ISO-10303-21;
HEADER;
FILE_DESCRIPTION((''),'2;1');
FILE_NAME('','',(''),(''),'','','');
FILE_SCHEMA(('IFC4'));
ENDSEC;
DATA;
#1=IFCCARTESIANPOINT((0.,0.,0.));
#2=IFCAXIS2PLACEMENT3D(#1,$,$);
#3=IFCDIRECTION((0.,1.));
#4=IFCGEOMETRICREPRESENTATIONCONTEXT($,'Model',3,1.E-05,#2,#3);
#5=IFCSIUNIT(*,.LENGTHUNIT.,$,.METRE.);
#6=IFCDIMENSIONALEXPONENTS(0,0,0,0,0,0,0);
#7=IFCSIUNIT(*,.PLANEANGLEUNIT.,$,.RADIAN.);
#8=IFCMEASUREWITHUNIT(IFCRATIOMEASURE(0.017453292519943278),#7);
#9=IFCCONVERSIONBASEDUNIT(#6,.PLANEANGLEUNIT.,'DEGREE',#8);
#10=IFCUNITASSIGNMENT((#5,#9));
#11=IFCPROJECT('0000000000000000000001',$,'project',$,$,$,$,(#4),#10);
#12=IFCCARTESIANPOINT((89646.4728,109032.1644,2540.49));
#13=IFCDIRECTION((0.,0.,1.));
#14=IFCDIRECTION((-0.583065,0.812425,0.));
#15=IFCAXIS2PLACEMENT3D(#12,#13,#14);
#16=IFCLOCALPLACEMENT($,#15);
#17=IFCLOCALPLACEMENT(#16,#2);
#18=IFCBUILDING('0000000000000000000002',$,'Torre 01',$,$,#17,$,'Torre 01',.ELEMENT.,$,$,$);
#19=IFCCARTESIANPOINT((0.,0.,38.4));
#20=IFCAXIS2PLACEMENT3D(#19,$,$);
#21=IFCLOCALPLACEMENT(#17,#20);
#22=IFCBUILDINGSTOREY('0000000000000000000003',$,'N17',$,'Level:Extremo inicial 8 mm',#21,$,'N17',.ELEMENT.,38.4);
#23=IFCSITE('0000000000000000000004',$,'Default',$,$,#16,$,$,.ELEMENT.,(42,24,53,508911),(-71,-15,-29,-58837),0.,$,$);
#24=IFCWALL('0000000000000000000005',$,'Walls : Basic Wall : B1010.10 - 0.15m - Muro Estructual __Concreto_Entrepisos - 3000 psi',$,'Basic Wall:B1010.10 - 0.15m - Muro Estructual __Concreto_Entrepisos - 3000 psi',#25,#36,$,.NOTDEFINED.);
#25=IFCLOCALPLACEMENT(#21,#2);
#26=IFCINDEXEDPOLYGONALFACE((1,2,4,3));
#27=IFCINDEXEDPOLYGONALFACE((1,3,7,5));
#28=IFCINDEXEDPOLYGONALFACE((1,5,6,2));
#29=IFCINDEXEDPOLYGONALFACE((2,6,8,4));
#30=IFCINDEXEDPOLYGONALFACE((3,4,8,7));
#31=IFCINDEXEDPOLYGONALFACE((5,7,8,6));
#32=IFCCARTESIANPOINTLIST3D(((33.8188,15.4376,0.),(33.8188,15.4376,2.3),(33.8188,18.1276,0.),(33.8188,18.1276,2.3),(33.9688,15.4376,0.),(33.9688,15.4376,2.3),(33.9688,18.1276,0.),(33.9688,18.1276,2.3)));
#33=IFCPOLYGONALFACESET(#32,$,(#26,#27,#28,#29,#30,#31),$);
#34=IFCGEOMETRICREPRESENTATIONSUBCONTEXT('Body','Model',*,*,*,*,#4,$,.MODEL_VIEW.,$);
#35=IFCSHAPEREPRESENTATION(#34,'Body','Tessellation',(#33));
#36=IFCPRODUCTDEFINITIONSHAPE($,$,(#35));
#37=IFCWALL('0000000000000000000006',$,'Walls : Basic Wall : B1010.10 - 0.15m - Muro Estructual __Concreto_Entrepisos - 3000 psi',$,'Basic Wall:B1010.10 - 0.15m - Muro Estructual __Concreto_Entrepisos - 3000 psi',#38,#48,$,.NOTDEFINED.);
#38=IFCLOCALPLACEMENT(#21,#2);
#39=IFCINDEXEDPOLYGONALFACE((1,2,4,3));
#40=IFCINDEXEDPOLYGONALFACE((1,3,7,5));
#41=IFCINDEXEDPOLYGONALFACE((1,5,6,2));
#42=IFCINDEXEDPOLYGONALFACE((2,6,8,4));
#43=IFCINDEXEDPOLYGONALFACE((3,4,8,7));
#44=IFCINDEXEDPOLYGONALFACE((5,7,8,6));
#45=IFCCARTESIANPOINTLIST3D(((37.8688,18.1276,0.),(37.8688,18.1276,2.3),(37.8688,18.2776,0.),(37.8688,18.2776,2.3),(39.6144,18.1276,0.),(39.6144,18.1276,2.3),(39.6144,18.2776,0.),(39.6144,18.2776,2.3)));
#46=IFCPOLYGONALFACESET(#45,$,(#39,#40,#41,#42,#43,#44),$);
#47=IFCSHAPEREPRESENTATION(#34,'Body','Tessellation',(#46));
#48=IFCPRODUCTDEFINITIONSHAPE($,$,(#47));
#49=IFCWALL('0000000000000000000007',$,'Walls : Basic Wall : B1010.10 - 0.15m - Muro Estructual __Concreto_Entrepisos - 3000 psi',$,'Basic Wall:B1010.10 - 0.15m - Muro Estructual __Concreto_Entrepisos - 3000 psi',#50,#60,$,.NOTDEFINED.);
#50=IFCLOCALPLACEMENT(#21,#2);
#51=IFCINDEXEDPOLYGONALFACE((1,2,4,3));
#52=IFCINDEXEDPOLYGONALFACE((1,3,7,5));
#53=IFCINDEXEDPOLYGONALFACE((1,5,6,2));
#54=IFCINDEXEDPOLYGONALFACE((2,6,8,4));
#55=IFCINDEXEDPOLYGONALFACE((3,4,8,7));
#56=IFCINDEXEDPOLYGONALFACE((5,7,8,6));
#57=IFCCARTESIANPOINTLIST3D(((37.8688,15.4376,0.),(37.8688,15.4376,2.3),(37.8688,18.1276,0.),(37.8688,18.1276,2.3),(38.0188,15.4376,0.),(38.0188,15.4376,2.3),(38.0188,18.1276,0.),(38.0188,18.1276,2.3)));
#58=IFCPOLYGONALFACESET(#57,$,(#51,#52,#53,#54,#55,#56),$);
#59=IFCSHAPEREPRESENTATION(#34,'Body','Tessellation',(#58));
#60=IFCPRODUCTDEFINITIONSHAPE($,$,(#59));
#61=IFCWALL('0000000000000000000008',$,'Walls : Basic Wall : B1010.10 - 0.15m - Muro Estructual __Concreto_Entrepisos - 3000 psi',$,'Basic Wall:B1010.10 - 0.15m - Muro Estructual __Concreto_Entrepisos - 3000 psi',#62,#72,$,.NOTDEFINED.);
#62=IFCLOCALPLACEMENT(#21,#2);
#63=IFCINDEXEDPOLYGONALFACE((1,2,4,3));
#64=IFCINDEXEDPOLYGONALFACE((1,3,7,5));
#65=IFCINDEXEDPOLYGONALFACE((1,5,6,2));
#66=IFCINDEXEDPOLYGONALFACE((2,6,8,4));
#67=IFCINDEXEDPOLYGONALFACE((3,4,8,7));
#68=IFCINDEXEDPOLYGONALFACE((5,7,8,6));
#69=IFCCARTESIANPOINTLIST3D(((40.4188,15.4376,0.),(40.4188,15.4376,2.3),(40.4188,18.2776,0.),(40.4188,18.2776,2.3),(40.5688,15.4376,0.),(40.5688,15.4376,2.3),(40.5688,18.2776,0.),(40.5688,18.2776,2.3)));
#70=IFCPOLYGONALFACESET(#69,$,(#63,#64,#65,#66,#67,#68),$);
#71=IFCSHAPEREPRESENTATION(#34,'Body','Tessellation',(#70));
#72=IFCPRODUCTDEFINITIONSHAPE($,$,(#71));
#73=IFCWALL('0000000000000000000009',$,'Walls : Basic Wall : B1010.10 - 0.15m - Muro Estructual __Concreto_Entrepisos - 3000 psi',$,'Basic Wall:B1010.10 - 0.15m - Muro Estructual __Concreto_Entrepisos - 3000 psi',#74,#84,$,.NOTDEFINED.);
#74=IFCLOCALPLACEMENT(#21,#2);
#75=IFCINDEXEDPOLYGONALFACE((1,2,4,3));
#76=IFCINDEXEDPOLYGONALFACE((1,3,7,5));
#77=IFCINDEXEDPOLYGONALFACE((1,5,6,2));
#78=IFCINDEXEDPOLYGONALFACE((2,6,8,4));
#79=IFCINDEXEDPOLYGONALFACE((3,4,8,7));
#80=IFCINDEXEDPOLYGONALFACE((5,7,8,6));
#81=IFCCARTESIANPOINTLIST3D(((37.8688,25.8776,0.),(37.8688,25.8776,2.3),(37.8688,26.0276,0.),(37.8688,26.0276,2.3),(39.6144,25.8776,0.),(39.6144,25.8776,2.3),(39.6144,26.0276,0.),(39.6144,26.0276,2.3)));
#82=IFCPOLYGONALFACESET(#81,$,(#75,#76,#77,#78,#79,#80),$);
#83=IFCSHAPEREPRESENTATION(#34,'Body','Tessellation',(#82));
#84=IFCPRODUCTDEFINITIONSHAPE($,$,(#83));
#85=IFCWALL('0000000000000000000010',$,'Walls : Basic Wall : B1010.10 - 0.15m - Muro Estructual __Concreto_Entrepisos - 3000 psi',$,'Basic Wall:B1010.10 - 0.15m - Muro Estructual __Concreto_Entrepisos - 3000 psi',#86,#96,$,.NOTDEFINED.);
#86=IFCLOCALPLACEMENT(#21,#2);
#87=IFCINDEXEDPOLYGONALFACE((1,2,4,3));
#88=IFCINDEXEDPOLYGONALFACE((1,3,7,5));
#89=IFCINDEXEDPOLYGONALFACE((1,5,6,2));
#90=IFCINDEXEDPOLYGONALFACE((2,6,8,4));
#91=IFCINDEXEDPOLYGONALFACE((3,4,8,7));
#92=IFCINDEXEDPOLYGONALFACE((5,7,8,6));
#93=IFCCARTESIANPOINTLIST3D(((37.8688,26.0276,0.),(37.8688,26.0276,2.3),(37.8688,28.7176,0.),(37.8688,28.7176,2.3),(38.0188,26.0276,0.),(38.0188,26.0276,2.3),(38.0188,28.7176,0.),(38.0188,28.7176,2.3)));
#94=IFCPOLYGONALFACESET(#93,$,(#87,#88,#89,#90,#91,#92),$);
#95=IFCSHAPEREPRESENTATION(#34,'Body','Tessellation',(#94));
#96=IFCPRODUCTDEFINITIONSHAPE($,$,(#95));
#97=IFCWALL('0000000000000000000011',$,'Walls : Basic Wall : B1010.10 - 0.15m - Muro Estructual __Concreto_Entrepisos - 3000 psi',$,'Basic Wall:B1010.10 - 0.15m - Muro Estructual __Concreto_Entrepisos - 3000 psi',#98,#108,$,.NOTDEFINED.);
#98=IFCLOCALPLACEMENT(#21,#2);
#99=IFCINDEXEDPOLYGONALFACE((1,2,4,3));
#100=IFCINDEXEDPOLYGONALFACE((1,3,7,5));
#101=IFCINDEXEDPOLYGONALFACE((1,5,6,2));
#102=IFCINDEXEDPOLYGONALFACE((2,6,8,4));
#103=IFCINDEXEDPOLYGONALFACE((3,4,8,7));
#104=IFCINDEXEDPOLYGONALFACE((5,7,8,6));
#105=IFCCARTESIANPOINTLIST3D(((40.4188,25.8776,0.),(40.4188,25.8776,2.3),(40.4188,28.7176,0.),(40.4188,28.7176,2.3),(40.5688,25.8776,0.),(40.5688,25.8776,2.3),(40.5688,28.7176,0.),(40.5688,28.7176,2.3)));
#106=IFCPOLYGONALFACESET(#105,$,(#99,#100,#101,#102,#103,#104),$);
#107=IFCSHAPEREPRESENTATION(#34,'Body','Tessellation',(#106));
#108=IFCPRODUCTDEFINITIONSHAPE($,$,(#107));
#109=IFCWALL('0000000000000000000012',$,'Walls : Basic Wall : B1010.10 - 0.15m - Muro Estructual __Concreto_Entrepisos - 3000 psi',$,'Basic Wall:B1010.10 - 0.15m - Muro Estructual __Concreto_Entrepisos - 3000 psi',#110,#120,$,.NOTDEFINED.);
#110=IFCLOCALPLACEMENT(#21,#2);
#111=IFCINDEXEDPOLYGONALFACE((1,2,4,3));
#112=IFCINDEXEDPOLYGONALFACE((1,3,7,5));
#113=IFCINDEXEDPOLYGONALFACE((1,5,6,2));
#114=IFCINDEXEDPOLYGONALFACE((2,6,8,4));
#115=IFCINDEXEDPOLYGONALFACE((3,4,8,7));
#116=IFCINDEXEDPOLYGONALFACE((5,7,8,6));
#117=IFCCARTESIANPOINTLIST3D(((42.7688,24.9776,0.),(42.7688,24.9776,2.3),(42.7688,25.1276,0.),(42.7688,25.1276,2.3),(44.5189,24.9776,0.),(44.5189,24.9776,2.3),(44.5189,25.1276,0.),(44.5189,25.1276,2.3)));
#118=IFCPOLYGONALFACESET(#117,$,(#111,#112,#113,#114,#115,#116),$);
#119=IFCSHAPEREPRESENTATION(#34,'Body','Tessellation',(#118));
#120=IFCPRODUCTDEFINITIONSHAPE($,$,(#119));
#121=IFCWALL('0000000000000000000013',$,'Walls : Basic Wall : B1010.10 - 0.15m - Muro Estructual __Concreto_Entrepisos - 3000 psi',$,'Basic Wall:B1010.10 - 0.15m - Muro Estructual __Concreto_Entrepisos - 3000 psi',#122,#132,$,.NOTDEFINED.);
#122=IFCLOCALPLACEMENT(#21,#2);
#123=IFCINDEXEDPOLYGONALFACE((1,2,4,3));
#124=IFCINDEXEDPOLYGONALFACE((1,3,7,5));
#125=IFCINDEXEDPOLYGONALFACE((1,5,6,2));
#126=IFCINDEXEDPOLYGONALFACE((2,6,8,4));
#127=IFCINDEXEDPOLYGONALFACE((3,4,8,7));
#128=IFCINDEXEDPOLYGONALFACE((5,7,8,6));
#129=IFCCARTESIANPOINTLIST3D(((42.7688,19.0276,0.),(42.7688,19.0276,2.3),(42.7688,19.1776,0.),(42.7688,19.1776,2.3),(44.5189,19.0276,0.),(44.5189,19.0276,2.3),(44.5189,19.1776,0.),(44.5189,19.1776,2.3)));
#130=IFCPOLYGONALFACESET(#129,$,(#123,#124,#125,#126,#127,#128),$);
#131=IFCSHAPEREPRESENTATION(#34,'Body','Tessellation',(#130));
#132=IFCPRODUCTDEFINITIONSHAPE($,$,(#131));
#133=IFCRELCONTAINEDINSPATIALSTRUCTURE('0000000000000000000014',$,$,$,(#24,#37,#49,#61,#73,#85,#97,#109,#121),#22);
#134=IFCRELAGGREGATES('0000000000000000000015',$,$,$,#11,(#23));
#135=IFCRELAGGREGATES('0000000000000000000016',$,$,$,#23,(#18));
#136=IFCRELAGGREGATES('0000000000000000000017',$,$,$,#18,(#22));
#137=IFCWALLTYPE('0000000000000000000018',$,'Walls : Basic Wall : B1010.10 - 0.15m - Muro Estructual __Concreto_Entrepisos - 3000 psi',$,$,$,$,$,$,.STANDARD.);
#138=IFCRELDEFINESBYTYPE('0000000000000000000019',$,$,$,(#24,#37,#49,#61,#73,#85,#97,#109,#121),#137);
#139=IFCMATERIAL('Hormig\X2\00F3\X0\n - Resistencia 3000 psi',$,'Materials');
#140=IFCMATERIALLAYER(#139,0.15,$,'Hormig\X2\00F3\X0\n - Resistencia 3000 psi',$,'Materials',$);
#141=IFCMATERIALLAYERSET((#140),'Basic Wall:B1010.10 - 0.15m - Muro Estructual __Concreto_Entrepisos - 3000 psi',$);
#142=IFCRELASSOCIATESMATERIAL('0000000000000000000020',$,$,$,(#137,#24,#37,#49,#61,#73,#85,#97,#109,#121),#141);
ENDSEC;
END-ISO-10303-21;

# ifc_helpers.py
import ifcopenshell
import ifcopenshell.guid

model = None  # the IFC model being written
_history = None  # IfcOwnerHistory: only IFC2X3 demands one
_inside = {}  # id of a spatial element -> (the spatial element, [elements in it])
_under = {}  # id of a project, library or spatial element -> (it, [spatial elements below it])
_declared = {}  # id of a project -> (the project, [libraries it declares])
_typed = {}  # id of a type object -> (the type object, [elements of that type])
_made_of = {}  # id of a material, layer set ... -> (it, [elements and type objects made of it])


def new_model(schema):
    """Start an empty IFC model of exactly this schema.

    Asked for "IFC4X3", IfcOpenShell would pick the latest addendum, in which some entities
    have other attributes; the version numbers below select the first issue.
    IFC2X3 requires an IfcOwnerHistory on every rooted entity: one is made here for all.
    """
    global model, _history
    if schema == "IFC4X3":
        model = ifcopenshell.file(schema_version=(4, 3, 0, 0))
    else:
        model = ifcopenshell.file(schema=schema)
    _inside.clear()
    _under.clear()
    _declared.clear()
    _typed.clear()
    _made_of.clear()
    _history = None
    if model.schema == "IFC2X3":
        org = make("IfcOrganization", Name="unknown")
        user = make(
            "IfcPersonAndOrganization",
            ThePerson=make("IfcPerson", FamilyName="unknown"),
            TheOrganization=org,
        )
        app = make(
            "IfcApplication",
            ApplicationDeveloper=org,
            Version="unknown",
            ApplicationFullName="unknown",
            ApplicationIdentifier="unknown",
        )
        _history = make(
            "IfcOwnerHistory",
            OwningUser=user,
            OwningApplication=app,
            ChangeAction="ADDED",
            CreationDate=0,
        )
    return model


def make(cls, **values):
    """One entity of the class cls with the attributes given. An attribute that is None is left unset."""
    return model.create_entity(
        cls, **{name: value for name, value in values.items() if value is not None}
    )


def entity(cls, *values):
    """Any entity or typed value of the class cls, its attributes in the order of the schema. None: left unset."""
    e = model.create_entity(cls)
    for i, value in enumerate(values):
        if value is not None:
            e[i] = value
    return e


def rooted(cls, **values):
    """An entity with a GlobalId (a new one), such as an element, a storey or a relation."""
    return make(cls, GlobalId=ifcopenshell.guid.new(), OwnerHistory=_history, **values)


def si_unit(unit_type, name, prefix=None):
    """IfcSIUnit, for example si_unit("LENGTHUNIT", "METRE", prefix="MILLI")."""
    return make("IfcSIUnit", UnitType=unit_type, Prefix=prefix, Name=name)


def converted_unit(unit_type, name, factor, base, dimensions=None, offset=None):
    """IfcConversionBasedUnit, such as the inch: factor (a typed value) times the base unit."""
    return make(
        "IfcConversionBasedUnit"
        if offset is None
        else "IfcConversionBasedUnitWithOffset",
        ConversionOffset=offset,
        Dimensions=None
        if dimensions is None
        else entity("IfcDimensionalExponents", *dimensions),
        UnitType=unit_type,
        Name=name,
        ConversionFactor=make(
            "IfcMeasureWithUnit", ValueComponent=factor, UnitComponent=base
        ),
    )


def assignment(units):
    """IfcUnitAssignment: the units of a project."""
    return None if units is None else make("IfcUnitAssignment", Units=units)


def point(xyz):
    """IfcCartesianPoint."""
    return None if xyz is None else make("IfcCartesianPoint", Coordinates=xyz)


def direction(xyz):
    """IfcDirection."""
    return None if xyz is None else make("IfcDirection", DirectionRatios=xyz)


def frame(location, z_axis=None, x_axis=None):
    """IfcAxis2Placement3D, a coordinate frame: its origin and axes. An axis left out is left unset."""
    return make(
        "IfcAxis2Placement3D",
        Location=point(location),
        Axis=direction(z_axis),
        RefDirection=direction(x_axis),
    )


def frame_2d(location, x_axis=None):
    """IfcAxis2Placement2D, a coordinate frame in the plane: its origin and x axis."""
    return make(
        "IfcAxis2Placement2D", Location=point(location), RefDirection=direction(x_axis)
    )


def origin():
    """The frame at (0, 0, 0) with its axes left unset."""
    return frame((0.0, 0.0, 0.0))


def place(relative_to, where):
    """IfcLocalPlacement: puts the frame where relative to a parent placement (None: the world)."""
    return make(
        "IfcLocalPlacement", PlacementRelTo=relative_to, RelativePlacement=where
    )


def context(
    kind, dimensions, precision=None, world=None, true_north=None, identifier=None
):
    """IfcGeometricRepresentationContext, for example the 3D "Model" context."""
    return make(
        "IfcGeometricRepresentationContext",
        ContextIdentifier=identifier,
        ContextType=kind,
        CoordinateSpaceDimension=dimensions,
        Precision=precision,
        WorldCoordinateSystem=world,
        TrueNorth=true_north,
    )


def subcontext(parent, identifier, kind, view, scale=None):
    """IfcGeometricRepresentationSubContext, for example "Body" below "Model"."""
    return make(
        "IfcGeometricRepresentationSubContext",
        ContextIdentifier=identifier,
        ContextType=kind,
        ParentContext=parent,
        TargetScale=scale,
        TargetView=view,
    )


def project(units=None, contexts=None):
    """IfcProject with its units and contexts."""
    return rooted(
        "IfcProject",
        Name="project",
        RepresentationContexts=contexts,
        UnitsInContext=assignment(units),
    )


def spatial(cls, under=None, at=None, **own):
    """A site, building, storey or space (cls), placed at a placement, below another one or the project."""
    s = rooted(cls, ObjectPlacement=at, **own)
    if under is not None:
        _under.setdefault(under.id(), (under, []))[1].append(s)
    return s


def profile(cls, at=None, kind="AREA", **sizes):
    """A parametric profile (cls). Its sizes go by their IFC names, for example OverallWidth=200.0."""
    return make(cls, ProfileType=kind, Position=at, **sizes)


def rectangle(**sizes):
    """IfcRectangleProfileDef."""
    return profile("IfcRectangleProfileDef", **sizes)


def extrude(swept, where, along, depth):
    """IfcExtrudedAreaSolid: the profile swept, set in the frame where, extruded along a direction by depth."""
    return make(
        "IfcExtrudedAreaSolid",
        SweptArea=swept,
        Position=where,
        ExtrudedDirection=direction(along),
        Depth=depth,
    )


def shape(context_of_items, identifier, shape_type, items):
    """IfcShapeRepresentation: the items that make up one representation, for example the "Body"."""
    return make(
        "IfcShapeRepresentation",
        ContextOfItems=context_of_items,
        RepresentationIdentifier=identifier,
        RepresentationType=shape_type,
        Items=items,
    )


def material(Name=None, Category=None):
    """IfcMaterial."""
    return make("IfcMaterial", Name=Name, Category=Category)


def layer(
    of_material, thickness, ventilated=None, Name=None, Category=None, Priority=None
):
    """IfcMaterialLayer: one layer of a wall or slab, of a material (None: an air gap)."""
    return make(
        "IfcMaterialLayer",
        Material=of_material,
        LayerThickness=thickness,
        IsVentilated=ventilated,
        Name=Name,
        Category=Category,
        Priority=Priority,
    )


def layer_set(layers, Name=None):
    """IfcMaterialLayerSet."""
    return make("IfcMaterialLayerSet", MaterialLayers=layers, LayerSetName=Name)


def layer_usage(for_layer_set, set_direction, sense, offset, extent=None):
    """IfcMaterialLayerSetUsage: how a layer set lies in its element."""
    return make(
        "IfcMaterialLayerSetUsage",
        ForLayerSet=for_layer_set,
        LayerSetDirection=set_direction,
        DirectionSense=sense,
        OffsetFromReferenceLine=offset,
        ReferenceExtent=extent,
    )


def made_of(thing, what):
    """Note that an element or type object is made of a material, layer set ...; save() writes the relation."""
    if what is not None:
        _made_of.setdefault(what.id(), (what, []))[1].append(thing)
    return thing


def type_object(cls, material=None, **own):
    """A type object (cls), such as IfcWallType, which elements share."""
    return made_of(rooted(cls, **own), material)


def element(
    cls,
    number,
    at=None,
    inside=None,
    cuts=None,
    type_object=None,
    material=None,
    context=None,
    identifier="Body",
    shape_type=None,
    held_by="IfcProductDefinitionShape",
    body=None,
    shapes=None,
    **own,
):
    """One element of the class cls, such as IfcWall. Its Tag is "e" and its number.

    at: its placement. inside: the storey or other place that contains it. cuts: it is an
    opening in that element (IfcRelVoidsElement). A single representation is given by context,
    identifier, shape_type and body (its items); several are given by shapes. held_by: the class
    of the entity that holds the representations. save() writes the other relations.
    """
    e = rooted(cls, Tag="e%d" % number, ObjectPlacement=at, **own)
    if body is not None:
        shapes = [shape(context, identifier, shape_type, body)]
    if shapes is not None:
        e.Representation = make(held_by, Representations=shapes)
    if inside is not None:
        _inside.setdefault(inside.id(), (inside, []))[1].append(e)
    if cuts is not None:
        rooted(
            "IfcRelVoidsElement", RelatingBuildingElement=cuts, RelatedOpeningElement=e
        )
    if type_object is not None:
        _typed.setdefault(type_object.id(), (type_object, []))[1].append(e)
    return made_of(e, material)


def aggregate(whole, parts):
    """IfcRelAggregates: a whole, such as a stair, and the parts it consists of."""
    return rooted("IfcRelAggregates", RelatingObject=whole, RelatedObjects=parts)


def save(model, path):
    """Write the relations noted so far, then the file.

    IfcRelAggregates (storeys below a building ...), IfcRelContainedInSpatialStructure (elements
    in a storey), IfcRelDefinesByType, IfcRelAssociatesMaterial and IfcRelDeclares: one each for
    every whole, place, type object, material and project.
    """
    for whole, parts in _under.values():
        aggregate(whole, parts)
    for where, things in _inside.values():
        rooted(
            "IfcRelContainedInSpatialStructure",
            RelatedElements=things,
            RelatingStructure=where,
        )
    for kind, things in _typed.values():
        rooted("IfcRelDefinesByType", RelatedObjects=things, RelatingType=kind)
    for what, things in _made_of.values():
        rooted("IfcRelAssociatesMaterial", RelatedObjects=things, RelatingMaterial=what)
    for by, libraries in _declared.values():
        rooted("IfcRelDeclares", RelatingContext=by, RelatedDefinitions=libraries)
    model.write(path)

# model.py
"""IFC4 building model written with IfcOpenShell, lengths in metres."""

from ifc_helpers import new_model, entity, si_unit, converted_unit, direction, frame, frame_2d, origin, place, context, subcontext, project, spatial, rectangle, extrude, material, layer, layer_set, layer_usage, type_object, element, save


model = new_model("IFC4")

# Units and contexts
model_context = context("Model", 3, precision=1e-05, world=origin(), true_north=direction((0.0, 1.0)))
body_context = subcontext(model_context, "Body", "Model", "MODEL_VIEW")
ifc_project = project(units=[si_unit("LENGTHUNIT", "METRE"), converted_unit("PLANEANGLEUNIT", "DEGREE", entity("IfcRatioMeasure", 0.017453292519943278), si_unit("PLANEANGLEUNIT", "RADIAN"), dimensions=[0, 0, 0, 0, 0, 0, 0])], contexts=[model_context])

# Site, building, storey
site_placement = place(None, frame((89646.4728, 109032.1644, 2540.49), z_axis=(0.0, 0.0, 1.0), x_axis=(-0.583065, 0.812425, 0.0)))
site = spatial("IfcSite", under=ifc_project, at=site_placement, Name="Default", CompositionType="ELEMENT", RefLatitude=(42, 24, 53, 508911), RefLongitude=(-71, -15, -29, -58837), RefElevation=0.0)
building_placement = place(site_placement, origin())
building = spatial("IfcBuilding", under=site, at=building_placement, Name="Torre 01", LongName="Torre 01", CompositionType="ELEMENT")
storey_placement = place(building_placement, frame((0.0, 0.0, 38.4)))
storey = spatial("IfcBuildingStorey", under=building, at=storey_placement, Name="N17", ObjectType="Level:Extremo inicial 8 mm", LongName="N17", CompositionType="ELEMENT", Elevation=38.4)

# Walls
ifc_material = material(Name="Hormigón - Resistencia 3000 psi", Category="Materials")
ifc_layer_1 = layer(ifc_material, 0.15, Name="Hormigón - Resistencia 3000 psi", Category="Materials")
ifc_layer_set_1 = layer_set([ifc_layer_1], Name="Basic Wall:B1010.10 - 0.15m - Muro Estructual __Concreto_Entrepisos - 3000 psi")
wall_type_1 = type_object("IfcWallType", Name="Walls : Basic Wall : B1010.10 - 0.15m - Muro Estructual __Concreto_Entrepisos - 3000 psi", PredefinedType="STANDARD", material=ifc_layer_set_1)
ifc_layer_usage_1 = layer_usage(ifc_layer_set_1, "AXIS2", "NEGATIVE", 0.075)
wall_1_placement = place(storey_placement, frame((33.8938, 18.1276, 0.0), z_axis=(0.0, 0.0, 1.0), x_axis=(0.0, -1.0, 0.0)))
element("IfcWall", 1, at=wall_1_placement, inside=storey, type_object=wall_type_1, material=ifc_layer_usage_1, Name="Walls : Basic Wall : B1010.10 - 0.15m - Muro Estructual __Concreto_Entrepisos - 3000 psi", ObjectType="Basic Wall:B1010.10 - 0.15m - Muro Estructual __Concreto_Entrepisos - 3000 psi", PredefinedType="NOTDEFINED", context=body_context, shape_type="SweptSolid", body=[
    extrude(rectangle(XDim=2.69, YDim=0.15, at=frame_2d((1.345, 0.0), x_axis=(-1.0, 0.0))), origin(), (0.0, 0.0, 1.0), 2.3),
])
ifc_layer_usage_2 = layer_usage(ifc_layer_set_1, "AXIS2", "NEGATIVE", 0.075)
wall_2_placement = place(storey_placement, frame((39.6144, 18.2026, 0.0), z_axis=(0.0, 0.0, 1.0), x_axis=(-1.0, 0.0, 0.0)))
element("IfcWall", 2, at=wall_2_placement, inside=storey, type_object=wall_type_1, material=ifc_layer_usage_2, Name="Walls : Basic Wall : B1010.10 - 0.15m - Muro Estructual __Concreto_Entrepisos - 3000 psi", ObjectType="Basic Wall:B1010.10 - 0.15m - Muro Estructual __Concreto_Entrepisos - 3000 psi", PredefinedType="NOTDEFINED", context=body_context, shape_type="SweptSolid", body=[
    extrude(rectangle(XDim=1.7455, YDim=0.15, at=frame_2d((0.8728, 0.0), x_axis=(-1.0, 0.0))), origin(), (0.0, 0.0, 1.0), 2.3),
])
ifc_layer_usage_3 = layer_usage(ifc_layer_set_1, "AXIS2", "NEGATIVE", 0.075)
wall_3_placement = place(storey_placement, frame((37.9438, 18.1276, 0.0), z_axis=(0.0, 0.0, 1.0), x_axis=(0.0, -1.0, 0.0)))
element("IfcWall", 3, at=wall_3_placement, inside=storey, type_object=wall_type_1, material=ifc_layer_usage_3, Name="Walls : Basic Wall : B1010.10 - 0.15m - Muro Estructual __Concreto_Entrepisos - 3000 psi", ObjectType="Basic Wall:B1010.10 - 0.15m - Muro Estructual __Concreto_Entrepisos - 3000 psi", PredefinedType="NOTDEFINED", context=body_context, shape_type="SweptSolid", body=[
    extrude(rectangle(XDim=2.69, YDim=0.15, at=frame_2d((1.345, 0.0), x_axis=(-1.0, 0.0))), origin(), (0.0, 0.0, 1.0), 2.3),
])
ifc_layer_usage_4 = layer_usage(ifc_layer_set_1, "AXIS2", "NEGATIVE", 0.075)
wall_4_placement = place(storey_placement, frame((40.4938, 18.2776, 0.0), z_axis=(0.0, 0.0, 1.0), x_axis=(0.0, -1.0, 0.0)))
element("IfcWall", 4, at=wall_4_placement, inside=storey, type_object=wall_type_1, material=ifc_layer_usage_4, Name="Walls : Basic Wall : B1010.10 - 0.15m - Muro Estructual __Concreto_Entrepisos - 3000 psi", ObjectType="Basic Wall:B1010.10 - 0.15m - Muro Estructual __Concreto_Entrepisos - 3000 psi", PredefinedType="NOTDEFINED", context=body_context, shape_type="SweptSolid", body=[
    extrude(rectangle(XDim=2.84, YDim=0.15, at=frame_2d((1.42, 0.0), x_axis=(-1.0, 0.0))), origin(), (0.0, 0.0, 1.0), 2.3),
])
ifc_layer_usage_5 = layer_usage(ifc_layer_set_1, "AXIS2", "POSITIVE", -0.075)
wall_5_placement = place(storey_placement, frame((39.6144, 25.9526, 0.0), z_axis=(0.0, 0.0, 1.0), x_axis=(-1.0, 0.0, 0.0)))
element("IfcWall", 5, at=wall_5_placement, inside=storey, type_object=wall_type_1, material=ifc_layer_usage_5, Name="Walls : Basic Wall : B1010.10 - 0.15m - Muro Estructual __Concreto_Entrepisos - 3000 psi", ObjectType="Basic Wall:B1010.10 - 0.15m - Muro Estructual __Concreto_Entrepisos - 3000 psi", PredefinedType="NOTDEFINED", context=body_context, shape_type="SweptSolid", body=[
    extrude(rectangle(XDim=1.7455, YDim=0.15, at=frame_2d((0.8728, 0.0), x_axis=(-1.0, 0.0))), origin(), (0.0, 0.0, 1.0), 2.3),
])
ifc_layer_usage_6 = layer_usage(ifc_layer_set_1, "AXIS2", "POSITIVE", -0.075)
wall_6_placement = place(storey_placement, frame((37.9438, 26.0276, 0.0), z_axis=(0.0, 0.0, 1.0), x_axis=(0.0, 1.0, 0.0)))
element("IfcWall", 6, at=wall_6_placement, inside=storey, type_object=wall_type_1, material=ifc_layer_usage_6, Name="Walls : Basic Wall : B1010.10 - 0.15m - Muro Estructual __Concreto_Entrepisos - 3000 psi", ObjectType="Basic Wall:B1010.10 - 0.15m - Muro Estructual __Concreto_Entrepisos - 3000 psi", PredefinedType="NOTDEFINED", context=body_context, shape_type="SweptSolid", body=[
    extrude(rectangle(XDim=2.69, YDim=0.15, at=frame_2d((1.345, 0.0), x_axis=(-1.0, 0.0))), origin(), (0.0, 0.0, 1.0), 2.3),
])
ifc_layer_usage_7 = layer_usage(ifc_layer_set_1, "AXIS2", "POSITIVE", -0.075)
wall_7_placement = place(storey_placement, frame((40.4938, 25.8776, 0.0), z_axis=(0.0, 0.0, 1.0), x_axis=(0.0, 1.0, 0.0)))
element("IfcWall", 7, at=wall_7_placement, inside=storey, type_object=wall_type_1, material=ifc_layer_usage_7, Name="Walls : Basic Wall : B1010.10 - 0.15m - Muro Estructual __Concreto_Entrepisos - 3000 psi", ObjectType="Basic Wall:B1010.10 - 0.15m - Muro Estructual __Concreto_Entrepisos - 3000 psi", PredefinedType="NOTDEFINED", context=body_context, shape_type="SweptSolid", body=[
    extrude(rectangle(XDim=2.84, YDim=0.15, at=frame_2d((1.42, 0.0), x_axis=(-1.0, 0.0))), origin(), (0.0, 0.0, 1.0), 2.3),
])
ifc_layer_usage_8 = layer_usage(ifc_layer_set_1, "AXIS2", "NEGATIVE", 0.075)
wall_8_placement = place(storey_placement, frame((42.7688, 25.0526, 0.0)))
element("IfcWall", 8, at=wall_8_placement, inside=storey, type_object=wall_type_1, material=ifc_layer_usage_8, Name="Walls : Basic Wall : B1010.10 - 0.15m - Muro Estructual __Concreto_Entrepisos - 3000 psi", ObjectType="Basic Wall:B1010.10 - 0.15m - Muro Estructual __Concreto_Entrepisos - 3000 psi", PredefinedType="NOTDEFINED", context=body_context, shape_type="SweptSolid", body=[
    extrude(rectangle(XDim=1.75, YDim=0.15, at=frame_2d((0.875, 0.0), x_axis=(-1.0, 0.0))), origin(), (0.0, 0.0, 1.0), 2.3),
])
ifc_layer_usage_9 = layer_usage(ifc_layer_set_1, "AXIS2", "POSITIVE", -0.075)
wall_9_placement = place(storey_placement, frame((42.7688, 19.1026, 0.0)))
element("IfcWall", 9, at=wall_9_placement, inside=storey, type_object=wall_type_1, material=ifc_layer_usage_9, Name="Walls : Basic Wall : B1010.10 - 0.15m - Muro Estructual __Concreto_Entrepisos - 3000 psi", ObjectType="Basic Wall:B1010.10 - 0.15m - Muro Estructual __Concreto_Entrepisos - 3000 psi", PredefinedType="NOTDEFINED", context=body_context, shape_type="SweptSolid", body=[
    extrude(rectangle(XDim=1.75, YDim=0.15, at=frame_2d((0.875, 0.0), x_axis=(-1.0, 0.0))), origin(), (0.0, 0.0, 1.0), 2.3),
])

save(model, "model.ifc")
